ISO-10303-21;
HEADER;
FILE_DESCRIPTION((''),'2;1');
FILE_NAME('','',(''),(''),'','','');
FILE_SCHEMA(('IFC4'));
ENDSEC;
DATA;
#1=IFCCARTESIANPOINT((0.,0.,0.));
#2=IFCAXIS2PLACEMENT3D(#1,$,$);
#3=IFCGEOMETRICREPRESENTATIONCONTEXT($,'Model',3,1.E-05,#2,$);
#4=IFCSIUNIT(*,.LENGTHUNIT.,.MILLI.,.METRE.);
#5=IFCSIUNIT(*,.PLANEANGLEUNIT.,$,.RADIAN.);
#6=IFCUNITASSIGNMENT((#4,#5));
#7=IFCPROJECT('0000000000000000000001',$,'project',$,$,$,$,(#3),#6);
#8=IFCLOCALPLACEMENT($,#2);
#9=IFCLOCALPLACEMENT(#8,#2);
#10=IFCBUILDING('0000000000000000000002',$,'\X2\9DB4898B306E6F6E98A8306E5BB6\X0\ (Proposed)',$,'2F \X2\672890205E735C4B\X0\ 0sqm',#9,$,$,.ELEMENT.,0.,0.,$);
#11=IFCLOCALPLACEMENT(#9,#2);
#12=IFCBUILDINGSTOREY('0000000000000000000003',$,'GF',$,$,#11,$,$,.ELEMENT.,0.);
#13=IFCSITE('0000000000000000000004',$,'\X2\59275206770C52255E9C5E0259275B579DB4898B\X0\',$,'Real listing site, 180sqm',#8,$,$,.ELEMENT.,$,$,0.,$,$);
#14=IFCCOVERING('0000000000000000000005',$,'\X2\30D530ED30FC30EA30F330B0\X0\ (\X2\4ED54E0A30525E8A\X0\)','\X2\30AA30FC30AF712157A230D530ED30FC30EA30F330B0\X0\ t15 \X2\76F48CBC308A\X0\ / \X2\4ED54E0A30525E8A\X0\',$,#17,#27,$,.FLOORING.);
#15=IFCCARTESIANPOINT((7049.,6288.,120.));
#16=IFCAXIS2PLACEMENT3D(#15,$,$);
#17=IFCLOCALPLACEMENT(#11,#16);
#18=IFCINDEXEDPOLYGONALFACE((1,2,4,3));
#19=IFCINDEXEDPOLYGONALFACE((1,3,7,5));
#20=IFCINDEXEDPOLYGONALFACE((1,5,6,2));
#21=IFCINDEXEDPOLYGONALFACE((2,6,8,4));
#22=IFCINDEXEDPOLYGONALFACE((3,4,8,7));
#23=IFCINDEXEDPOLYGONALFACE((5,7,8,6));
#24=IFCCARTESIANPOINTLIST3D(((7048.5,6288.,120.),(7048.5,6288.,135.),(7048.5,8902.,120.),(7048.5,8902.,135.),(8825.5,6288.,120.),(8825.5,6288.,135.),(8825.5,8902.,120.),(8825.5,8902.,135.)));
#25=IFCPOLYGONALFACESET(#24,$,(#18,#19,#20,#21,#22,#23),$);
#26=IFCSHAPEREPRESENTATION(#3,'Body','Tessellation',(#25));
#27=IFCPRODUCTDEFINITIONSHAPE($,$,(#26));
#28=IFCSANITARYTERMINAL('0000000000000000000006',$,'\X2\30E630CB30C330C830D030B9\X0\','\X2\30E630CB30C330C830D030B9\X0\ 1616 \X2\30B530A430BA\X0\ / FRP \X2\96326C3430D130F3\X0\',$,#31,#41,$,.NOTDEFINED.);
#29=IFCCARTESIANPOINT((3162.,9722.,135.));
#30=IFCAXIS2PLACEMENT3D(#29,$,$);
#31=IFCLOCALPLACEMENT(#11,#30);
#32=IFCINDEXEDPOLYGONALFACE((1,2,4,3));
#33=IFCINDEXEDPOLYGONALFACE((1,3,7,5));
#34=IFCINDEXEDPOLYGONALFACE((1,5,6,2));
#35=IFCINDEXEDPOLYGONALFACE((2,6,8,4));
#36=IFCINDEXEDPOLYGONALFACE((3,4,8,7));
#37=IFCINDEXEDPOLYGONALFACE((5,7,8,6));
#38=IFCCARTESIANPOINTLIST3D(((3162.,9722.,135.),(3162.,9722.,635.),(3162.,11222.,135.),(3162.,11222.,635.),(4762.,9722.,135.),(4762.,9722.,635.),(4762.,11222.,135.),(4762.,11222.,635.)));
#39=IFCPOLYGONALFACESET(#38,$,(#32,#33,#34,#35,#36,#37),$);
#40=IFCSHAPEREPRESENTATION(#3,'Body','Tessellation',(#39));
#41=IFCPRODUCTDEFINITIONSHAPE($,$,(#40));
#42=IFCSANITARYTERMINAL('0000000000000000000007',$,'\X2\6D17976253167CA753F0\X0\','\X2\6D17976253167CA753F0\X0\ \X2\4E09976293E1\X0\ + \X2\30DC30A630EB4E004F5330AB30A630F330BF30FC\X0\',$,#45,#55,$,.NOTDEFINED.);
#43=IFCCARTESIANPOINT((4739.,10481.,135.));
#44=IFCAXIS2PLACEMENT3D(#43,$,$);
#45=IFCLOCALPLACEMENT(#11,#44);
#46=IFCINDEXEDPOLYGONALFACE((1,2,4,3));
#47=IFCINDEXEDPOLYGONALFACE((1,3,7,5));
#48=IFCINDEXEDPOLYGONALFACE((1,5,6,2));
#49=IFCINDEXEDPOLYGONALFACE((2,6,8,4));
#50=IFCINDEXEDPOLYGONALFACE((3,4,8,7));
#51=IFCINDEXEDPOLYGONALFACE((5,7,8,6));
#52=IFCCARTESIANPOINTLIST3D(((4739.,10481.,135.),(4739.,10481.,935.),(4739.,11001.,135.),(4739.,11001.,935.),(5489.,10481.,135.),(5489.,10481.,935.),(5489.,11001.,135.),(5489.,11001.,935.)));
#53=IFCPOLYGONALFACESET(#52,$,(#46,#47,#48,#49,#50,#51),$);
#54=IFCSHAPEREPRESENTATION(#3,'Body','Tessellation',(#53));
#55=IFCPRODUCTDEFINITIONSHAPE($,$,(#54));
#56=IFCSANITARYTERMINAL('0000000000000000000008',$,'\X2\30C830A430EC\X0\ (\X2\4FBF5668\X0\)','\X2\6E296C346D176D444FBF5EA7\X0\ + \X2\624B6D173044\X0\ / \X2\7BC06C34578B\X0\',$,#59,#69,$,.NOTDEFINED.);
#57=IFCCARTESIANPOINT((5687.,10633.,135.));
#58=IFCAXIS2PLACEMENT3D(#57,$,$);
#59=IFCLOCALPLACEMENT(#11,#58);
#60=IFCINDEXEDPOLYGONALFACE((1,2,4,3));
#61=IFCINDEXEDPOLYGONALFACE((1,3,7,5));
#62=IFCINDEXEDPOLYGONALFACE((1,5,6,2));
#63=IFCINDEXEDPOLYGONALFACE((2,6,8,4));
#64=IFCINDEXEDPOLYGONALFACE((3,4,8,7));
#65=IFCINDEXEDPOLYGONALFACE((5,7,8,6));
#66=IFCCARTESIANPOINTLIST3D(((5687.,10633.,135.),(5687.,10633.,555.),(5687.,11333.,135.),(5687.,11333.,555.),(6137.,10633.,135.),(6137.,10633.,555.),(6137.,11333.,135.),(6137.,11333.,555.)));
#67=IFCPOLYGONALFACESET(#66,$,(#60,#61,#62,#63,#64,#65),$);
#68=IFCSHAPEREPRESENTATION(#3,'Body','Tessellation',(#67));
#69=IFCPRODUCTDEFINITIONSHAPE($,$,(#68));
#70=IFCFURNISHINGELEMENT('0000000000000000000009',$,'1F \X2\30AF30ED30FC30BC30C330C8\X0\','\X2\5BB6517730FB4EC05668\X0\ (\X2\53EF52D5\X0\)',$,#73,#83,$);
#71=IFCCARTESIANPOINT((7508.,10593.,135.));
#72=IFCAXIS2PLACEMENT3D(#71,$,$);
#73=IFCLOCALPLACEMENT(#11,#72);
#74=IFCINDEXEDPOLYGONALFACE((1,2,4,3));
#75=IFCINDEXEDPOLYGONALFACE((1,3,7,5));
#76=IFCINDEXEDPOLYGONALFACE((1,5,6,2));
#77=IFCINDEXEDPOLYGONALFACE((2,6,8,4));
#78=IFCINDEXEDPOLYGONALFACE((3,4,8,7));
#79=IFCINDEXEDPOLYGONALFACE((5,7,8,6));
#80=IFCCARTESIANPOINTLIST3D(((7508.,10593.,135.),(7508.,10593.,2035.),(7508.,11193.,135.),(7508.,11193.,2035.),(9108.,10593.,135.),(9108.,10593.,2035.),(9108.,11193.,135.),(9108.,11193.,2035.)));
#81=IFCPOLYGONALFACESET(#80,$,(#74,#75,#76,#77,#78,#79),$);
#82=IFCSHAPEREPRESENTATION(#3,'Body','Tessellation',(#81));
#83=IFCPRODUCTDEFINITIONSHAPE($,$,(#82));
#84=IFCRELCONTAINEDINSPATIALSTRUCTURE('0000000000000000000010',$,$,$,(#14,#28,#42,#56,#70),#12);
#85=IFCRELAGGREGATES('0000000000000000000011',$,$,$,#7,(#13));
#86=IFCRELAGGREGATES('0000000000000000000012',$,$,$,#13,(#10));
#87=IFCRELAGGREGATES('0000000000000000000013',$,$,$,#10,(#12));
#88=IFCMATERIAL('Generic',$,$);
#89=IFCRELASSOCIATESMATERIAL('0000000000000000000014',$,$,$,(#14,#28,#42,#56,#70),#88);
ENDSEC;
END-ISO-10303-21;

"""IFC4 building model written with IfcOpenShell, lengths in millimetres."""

from ifc_helpers import new_model, si_unit, frame, frame_2d, origin, place, context, project, spatial, rectangle, extrude, material, element, save


model = new_model("IFC4")

# Units and contexts
model_context = context("Model", 3, precision=1e-05, world=origin())
ifc_project = project(units=[si_unit("LENGTHUNIT", "METRE", prefix="MILLI"), si_unit("PLANEANGLEUNIT", "RADIAN")], contexts=[model_context])

# Site, building, storey
site_placement = place(None, origin())
site = spatial("IfcSite", under=ifc_project, at=site_placement, Name="大分県別府市大字鶴見", ObjectType="Real listing site, 180sqm", CompositionType="ELEMENT", RefElevation=0.0)
building_placement = place(site_placement, origin())
building = spatial("IfcBuilding", under=site, at=building_placement, Name="鶴見の潮風の家 (Proposed)", ObjectType="2F 木造平屋 0sqm", CompositionType="ELEMENT", ElevationOfRefHeight=0.0, ElevationOfTerrain=0.0)
storey_placement = place(building_placement, origin())
storey = spatial("IfcBuildingStorey", under=building, at=storey_placement, Name="GF", CompositionType="ELEMENT", Elevation=0.0)

# Covering
ifc_material_1 = material(Name="Generic")
covering_1_placement = place(storey_placement, frame((7049.0, 6288.0, 120.0)))
element("IfcCovering", 1, at=covering_1_placement, inside=storey, material=ifc_material_1, Name="フローリング (仕上げ床)", Description="オーク無垢フローリング t15 直貼り / 仕上げ床", PredefinedType="FLOORING", context=model_context, shape_type="SweptSolid", body=[
    extrude(rectangle(XDim=1777.0, YDim=2614.0, at=frame_2d((888.0, 1307.0))), frame((7049.0, 6288.0, 120.0)), (0.0, 0.0, 1.0), 15.0),
])

# Sanitary terminals
sanitary_terminal_1_placement = place(storey_placement, frame((3162.0, 9722.0, 135.0)))
element("IfcSanitaryTerminal", 2, at=sanitary_terminal_1_placement, inside=storey, material=ifc_material_1, Name="ユニットバス", Description="ユニットバス 1616 サイズ / FRP 防水パン", PredefinedType="NOTDEFINED", context=model_context, shape_type="SweptSolid", body=[
    extrude(rectangle(XDim=1600.0, YDim=1500.0, at=frame_2d((800.0, 750.0))), frame((3162.0, 9722.0, 135.0)), (0.0, 0.0, 1.0), 500.0),
])
sanitary_terminal_2_placement = place(storey_placement, frame((4739.0, 10481.0, 135.0)))
element("IfcSanitaryTerminal", 3, at=sanitary_terminal_2_placement, inside=storey, material=ifc_material_1, Name="洗面化粧台", Description="洗面化粧台 三面鏡 + ボウル一体カウンター", PredefinedType="NOTDEFINED", context=model_context, shape_type="SweptSolid", body=[
    extrude(rectangle(XDim=750.0, YDim=520.0, at=frame_2d((375.0, 260.0))), frame((4739.0, 10481.0, 135.0)), (0.0, 0.0, 1.0), 800.0),
])
sanitary_terminal_3_placement = place(storey_placement, frame((5687.0, 10633.0, 135.0)))
element("IfcSanitaryTerminal", 4, at=sanitary_terminal_3_placement, inside=storey, material=ifc_material_1, Name="トイレ (便器)", Description="温水洗浄便座 + 手洗い / 節水型", PredefinedType="NOTDEFINED", context=model_context, shape_type="SweptSolid", body=[
    extrude(rectangle(XDim=450.0, YDim=700.0, at=frame_2d((225.0, 350.0))), frame((5687.0, 10633.0, 135.0)), (0.0, 0.0, 1.0), 420.0),
])

# Furnishing element
furnishing_placement = place(storey_placement, frame((7508.0, 10593.0, 135.0)))
element("IfcFurnishingElement", 5, at=furnishing_placement, inside=storey, material=ifc_material_1, Name="1F クローゼット", Description="家具・什器 (可動)", context=model_context, shape_type="SweptSolid", body=[
    extrude(rectangle(XDim=1600.0, YDim=600.0, at=frame_2d((800.0, 300.0))), frame((7508.0, 10593.0, 135.0)), (0.0, 0.0, 1.0), 1900.0),
])

save(model, "model.ifc")
